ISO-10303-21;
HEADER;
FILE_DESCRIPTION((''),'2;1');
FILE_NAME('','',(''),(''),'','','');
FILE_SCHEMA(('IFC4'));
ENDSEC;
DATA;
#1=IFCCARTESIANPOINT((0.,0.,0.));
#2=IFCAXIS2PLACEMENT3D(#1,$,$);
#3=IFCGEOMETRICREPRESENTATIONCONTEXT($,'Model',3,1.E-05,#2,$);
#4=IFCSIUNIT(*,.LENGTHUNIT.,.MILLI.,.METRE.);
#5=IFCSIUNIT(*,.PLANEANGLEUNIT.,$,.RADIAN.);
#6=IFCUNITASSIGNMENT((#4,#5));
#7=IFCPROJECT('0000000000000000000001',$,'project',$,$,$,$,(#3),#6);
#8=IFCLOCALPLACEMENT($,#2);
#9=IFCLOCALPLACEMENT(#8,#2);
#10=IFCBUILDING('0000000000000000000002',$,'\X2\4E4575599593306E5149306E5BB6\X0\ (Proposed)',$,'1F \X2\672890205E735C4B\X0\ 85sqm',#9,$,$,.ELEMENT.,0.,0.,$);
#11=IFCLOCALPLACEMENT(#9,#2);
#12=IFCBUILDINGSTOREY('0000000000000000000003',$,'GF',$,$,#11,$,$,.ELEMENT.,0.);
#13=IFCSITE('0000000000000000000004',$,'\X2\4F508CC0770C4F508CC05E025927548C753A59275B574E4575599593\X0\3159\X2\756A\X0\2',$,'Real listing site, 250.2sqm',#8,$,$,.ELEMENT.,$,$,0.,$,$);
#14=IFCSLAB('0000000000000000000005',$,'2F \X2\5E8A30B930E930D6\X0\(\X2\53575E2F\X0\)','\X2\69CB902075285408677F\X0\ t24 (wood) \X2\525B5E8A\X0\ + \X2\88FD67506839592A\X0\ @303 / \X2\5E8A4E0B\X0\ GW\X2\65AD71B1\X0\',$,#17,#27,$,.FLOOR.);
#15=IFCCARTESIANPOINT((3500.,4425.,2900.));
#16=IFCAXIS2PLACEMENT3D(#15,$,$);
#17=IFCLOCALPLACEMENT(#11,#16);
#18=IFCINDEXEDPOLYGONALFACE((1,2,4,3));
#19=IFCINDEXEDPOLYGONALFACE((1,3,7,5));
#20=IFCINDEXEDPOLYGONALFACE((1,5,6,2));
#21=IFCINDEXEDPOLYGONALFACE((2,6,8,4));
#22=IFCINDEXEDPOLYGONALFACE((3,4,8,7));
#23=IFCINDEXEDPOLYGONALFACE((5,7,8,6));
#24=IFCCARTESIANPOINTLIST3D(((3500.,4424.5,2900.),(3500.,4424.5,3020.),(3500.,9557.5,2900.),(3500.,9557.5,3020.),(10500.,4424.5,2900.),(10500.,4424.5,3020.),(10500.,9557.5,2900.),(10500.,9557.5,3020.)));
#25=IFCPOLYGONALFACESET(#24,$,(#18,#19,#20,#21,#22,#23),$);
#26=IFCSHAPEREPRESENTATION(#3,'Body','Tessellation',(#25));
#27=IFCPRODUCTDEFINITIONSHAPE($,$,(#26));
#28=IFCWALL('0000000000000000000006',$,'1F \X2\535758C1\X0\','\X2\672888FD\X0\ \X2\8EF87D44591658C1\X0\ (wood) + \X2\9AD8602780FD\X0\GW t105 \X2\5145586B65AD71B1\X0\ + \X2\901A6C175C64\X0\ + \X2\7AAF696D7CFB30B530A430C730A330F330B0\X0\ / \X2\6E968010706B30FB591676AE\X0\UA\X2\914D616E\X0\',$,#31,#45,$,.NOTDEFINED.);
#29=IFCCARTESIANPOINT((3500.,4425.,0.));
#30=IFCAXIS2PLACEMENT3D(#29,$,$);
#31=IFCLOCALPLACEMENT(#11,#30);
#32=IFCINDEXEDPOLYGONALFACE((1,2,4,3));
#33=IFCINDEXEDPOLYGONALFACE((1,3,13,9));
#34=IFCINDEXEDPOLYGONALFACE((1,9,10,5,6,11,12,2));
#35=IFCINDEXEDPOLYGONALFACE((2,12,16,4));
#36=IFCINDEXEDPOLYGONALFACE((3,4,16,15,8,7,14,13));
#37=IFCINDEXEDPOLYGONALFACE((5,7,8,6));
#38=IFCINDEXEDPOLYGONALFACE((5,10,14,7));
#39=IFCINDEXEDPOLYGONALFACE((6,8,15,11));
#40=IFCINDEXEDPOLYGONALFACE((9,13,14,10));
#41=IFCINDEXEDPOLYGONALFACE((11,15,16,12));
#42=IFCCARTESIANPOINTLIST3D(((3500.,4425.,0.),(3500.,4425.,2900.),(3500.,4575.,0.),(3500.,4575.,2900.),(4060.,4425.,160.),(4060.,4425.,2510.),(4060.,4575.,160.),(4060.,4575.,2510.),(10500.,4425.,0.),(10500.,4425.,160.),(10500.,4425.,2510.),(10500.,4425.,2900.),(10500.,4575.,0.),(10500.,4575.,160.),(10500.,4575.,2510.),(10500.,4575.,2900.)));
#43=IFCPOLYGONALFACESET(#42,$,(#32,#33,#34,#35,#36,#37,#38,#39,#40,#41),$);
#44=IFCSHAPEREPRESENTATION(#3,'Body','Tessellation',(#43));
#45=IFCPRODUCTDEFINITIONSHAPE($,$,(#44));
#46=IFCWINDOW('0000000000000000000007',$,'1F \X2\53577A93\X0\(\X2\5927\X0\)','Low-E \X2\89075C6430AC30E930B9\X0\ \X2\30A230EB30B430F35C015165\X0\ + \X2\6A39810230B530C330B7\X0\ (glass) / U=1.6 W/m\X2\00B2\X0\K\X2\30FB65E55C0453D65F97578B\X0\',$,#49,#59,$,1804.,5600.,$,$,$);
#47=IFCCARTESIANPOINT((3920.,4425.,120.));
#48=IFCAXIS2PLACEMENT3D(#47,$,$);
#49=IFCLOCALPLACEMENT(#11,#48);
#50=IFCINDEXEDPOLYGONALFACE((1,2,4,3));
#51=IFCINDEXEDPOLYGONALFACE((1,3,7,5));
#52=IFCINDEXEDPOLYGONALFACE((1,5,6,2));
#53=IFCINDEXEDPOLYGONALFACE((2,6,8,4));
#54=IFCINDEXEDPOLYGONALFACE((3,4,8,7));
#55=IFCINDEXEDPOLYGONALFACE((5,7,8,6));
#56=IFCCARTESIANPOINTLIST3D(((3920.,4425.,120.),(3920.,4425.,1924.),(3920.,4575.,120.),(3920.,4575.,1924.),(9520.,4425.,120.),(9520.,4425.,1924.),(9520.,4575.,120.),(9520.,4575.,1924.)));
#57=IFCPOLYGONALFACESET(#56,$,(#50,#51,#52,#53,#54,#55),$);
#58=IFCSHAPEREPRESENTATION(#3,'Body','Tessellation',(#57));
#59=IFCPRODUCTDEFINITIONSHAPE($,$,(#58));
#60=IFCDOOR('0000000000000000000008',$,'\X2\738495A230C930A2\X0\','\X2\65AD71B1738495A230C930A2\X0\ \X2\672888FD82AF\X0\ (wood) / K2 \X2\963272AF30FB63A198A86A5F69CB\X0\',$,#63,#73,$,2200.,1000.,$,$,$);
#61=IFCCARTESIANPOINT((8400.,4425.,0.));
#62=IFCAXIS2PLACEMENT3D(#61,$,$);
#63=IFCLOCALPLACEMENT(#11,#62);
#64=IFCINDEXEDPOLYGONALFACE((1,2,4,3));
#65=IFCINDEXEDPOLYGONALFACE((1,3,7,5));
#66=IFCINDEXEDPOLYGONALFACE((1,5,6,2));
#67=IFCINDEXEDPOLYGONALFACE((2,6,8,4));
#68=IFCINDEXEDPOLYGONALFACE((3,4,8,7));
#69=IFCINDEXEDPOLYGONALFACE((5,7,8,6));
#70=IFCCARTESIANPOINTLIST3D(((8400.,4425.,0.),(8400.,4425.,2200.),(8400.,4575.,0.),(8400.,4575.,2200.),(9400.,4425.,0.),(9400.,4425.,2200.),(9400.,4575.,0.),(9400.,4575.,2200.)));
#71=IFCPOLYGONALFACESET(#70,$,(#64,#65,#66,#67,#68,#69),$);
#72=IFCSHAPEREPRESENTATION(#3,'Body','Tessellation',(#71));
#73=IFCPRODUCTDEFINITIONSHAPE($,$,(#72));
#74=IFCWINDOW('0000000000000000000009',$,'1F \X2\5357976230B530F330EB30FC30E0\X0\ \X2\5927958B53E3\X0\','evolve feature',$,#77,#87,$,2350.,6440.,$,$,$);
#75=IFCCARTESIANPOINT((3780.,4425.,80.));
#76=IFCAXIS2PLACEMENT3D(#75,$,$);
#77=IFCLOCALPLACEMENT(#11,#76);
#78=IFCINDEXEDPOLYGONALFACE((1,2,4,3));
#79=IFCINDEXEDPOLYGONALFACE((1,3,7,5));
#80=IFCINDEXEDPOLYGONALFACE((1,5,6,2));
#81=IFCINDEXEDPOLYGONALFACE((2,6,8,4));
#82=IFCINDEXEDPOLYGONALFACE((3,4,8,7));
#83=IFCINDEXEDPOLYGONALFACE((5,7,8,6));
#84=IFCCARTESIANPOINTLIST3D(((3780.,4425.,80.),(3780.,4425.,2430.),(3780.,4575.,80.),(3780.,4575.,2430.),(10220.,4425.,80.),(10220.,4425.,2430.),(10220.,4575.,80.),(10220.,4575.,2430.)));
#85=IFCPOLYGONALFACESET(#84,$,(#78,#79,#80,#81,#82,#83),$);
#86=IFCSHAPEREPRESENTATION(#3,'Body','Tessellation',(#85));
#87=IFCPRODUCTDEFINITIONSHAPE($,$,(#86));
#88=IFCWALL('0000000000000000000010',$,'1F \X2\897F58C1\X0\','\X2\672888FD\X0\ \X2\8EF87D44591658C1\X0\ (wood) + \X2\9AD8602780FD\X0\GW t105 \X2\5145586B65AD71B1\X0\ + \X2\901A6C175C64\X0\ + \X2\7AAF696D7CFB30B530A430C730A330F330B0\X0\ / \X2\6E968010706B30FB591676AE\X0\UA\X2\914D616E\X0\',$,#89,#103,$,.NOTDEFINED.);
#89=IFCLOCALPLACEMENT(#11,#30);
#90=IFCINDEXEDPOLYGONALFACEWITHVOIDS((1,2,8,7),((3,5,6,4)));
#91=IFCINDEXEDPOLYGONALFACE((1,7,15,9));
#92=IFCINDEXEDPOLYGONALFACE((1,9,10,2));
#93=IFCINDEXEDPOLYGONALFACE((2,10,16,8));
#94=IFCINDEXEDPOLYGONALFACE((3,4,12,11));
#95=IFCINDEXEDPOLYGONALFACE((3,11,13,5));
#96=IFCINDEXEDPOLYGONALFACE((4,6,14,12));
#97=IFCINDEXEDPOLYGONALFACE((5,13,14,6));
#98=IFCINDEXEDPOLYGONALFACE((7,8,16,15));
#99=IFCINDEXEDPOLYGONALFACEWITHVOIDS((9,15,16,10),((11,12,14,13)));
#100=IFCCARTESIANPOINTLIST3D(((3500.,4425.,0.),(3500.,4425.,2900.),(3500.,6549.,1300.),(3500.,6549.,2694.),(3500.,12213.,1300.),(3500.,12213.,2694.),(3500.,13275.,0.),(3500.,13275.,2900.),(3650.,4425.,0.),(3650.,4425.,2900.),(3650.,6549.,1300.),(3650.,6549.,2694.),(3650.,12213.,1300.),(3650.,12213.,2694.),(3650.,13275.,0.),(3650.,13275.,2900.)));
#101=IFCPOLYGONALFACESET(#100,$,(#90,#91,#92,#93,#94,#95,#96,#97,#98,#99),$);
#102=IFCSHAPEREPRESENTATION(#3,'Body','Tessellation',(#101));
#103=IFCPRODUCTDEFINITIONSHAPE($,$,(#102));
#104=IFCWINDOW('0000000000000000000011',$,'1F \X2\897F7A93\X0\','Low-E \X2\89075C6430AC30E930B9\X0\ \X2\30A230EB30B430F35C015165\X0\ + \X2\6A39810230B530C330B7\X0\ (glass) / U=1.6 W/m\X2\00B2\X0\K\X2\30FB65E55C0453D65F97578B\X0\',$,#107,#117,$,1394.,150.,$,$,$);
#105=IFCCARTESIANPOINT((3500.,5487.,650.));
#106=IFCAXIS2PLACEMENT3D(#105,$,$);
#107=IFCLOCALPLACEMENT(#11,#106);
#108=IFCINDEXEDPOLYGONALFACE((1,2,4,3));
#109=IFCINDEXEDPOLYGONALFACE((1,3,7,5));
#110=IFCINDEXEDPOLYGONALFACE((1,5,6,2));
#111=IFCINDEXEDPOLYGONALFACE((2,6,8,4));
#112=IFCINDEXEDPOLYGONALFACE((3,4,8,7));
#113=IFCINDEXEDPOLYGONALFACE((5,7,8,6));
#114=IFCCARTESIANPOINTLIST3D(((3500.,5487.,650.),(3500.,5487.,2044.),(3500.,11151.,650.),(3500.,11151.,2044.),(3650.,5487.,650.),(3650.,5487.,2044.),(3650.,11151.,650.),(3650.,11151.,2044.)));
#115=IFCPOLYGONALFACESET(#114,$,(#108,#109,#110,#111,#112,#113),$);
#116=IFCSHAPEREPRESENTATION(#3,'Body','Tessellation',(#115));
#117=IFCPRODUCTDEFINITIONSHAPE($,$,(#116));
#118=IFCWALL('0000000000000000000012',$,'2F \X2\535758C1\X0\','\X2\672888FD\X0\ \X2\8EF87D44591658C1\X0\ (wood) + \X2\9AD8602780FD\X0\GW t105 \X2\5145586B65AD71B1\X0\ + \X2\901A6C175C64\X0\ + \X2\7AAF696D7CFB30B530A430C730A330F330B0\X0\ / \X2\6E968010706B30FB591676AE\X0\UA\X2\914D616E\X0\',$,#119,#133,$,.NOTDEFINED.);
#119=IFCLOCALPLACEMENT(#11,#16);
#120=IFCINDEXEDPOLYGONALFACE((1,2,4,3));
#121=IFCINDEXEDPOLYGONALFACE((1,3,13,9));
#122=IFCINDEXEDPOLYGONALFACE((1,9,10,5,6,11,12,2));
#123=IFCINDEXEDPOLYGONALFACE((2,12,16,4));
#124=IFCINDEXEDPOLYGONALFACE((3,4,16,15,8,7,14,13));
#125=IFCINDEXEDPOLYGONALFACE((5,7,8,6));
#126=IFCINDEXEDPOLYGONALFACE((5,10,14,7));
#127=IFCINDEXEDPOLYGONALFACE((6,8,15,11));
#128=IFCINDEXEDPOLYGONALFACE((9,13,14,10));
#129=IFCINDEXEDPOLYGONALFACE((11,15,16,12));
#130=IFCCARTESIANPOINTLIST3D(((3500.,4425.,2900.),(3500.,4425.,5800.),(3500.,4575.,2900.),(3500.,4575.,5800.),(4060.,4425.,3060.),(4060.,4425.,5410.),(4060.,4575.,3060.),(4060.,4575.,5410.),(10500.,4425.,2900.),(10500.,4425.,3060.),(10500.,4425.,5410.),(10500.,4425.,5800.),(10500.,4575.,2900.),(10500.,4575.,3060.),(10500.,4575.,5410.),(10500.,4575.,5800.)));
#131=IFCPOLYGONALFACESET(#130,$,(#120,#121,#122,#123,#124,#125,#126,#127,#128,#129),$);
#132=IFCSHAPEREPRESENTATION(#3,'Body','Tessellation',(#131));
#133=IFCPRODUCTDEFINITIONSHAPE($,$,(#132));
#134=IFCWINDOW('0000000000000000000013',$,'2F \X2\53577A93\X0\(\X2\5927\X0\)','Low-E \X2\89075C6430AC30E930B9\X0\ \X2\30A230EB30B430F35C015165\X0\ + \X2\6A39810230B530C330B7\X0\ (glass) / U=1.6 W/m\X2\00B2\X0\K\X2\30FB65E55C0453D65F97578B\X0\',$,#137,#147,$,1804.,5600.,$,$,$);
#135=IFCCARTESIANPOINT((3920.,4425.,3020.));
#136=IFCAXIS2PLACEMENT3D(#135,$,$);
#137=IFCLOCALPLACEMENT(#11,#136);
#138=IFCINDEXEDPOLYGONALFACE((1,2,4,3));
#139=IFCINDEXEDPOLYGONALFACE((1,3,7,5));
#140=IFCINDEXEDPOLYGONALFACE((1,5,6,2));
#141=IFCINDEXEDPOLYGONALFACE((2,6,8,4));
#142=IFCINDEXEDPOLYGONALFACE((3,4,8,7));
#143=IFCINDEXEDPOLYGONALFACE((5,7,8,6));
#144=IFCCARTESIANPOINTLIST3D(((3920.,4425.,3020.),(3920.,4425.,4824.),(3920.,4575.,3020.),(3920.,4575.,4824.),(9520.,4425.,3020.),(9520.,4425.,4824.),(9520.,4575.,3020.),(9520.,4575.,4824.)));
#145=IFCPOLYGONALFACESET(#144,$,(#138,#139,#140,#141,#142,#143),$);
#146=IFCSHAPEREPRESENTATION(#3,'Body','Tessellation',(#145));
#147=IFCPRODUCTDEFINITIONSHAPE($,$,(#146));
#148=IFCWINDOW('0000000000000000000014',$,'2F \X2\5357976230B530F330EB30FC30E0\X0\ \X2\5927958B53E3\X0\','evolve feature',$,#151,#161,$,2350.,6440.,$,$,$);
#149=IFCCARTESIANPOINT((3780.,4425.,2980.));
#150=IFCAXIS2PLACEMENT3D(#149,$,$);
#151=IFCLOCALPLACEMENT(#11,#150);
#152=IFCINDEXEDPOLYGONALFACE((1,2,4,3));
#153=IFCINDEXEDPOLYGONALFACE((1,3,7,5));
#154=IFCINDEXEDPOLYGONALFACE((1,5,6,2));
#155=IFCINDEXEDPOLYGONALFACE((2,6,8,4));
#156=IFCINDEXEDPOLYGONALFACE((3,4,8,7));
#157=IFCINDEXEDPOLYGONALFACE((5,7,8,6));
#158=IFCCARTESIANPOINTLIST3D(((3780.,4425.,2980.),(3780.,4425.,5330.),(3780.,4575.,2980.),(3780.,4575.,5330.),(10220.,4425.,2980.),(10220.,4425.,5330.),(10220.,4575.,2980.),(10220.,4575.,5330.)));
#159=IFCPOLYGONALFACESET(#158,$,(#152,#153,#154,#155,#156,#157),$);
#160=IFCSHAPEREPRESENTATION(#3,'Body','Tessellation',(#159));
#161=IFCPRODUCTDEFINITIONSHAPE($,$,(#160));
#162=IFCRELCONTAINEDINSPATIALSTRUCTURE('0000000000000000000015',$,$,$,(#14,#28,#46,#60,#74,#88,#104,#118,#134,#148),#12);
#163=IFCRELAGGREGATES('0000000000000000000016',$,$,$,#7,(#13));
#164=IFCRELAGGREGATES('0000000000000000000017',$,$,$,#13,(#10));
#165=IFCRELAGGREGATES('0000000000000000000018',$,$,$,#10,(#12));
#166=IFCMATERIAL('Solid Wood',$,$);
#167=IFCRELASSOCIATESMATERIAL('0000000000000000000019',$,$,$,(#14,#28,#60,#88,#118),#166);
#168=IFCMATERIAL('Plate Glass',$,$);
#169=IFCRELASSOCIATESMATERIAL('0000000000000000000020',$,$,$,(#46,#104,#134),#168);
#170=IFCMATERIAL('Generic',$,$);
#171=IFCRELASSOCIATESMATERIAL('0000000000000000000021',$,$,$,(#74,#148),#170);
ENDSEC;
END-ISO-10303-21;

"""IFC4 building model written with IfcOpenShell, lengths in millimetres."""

from ifc_helpers import new_model, si_unit, frame, frame_2d, origin, place, context, project, spatial, rectangle, extrude, material, element, fill, save


model = new_model("IFC4")

# Units and contexts
model_context = context("Model", 3, precision=1e-05, world=origin())
ifc_project = project(units=[si_unit("LENGTHUNIT", "METRE", prefix="MILLI"), si_unit("PLANEANGLEUNIT", "RADIAN")], contexts=[model_context])

# Site, building, storey
site_placement = place(None, origin())
site = spatial("IfcSite", under=ifc_project, at=site_placement, Name="佐賀県佐賀市大和町大字久留間3159番2", ObjectType="Real listing site, 250.2sqm", CompositionType="ELEMENT", RefElevation=0.0)
building_placement = place(site_placement, origin())
building = spatial("IfcBuilding", under=site, at=building_placement, Name="久留間の光の家 (Proposed)", ObjectType="1F 木造平屋 85sqm", CompositionType="ELEMENT", ElevationOfRefHeight=0.0, ElevationOfTerrain=0.0)
storey_placement = place(building_placement, origin())
storey = spatial("IfcBuildingStorey", under=building, at=storey_placement, Name="GF", CompositionType="ELEMENT", Elevation=0.0)

# Slab
ifc_material_1 = material(Name="Solid Wood")
slab_1_placement = place(storey_placement, frame((3500.0, 4425.0, 2900.0)))
element("IfcSlab", 1, at=slab_1_placement, inside=storey, material=ifc_material_1, Name="2F 床スラブ(南帯)", Description="構造用合板 t24 (wood) 剛床 + 製材根太 @303 / 床下 GW断熱", PredefinedType="FLOOR", context=model_context, shape_type="SweptSolid", body=[
    extrude(rectangle(XDim=7000.0, YDim=5133.0, at=frame_2d((3500.0, 2566.0))), frame((3500.0, 4425.0, 2900.0)), (0.0, 0.0, 1.0), 120.0),
])
ifc_material_2 = material(Name="Generic")

# Wall, openings, windows, door
wall_1_placement = place(storey_placement, frame((3500.0, 4425.0, 0.0)))
wall_1 = element("IfcWall", 2, at=wall_1_placement, inside=storey, material=ifc_material_1, Name="1F 南壁", Description="木製 軸組外壁 (wood) + 高性能GW t105 充填断熱 + 通気層 + 窯業系サイディング / 準耐火・外皮UA配慮", PredefinedType="NOTDEFINED", context=model_context, shape_type="SweptSolid", body=[
    extrude(rectangle(XDim=7000.0, YDim=150.0, at=frame_2d((3500.0, 75.0))), frame((3500.0, 4425.0, 0.0)), (0.0, 0.0, 1.0), 2900.0),
])
opening_1_placement = place(storey_placement, frame((3920.0, 4425.0, 120.0)))
opening_1 = element("IfcOpeningElement", 3, at=opening_1_placement, cuts=wall_1, PredefinedType="NOTDEFINED", context=model_context, shape_type="SweptSolid", body=[
    extrude(rectangle(XDim=5600.0, YDim=150.0, at=frame_2d((2800.0, 75.0))), frame((3920.0, 4425.0, 120.0)), (0.0, 0.0, 1.0), 1804.0),
])
opening_2_placement = place(storey_placement, frame((8400.0, 4425.0, 0.0)))
opening_2 = element("IfcOpeningElement", 4, at=opening_2_placement, cuts=wall_1, PredefinedType="NOTDEFINED", context=model_context, shape_type="SweptSolid", body=[
    extrude(rectangle(XDim=1000.0, YDim=150.0, at=frame_2d((500.0, 75.0))), frame((8400.0, 4425.0, 0.0)), (0.0, 0.0, 1.0), 2200.0),
])
opening_3_placement = place(storey_placement, frame((3780.0, 4425.0, 80.0)))
opening_3 = element("IfcOpeningElement", 5, at=opening_3_placement, cuts=wall_1, PredefinedType="NOTDEFINED", context=model_context, shape_type="SweptSolid", body=[
    extrude(rectangle(XDim=6440.0, YDim=150.0, at=frame_2d((3220.0, 75.0))), frame((3780.0, 4425.0, 80.0)), (0.0, 0.0, 1.0), 2350.0),
])
ifc_material_3 = material(Name="Plate Glass")
window_1_placement = place(storey_placement, frame((3920.0, 4425.0, 120.0)))
window_1 = element("IfcWindow", 6, at=window_1_placement, inside=storey, material=ifc_material_3, Name="1F 南窓(大)", Description="Low-E 複層ガラス アルゴン封入 + 樹脂サッシ (glass) / U=1.6 W/m²K・日射取得型", OverallHeight=1804.0, OverallWidth=5600.0, context=model_context, shape_type="SweptSolid", body=[
    extrude(rectangle(XDim=5600.0, YDim=150.0, at=frame_2d((2800.0, 75.0))), frame((3920.0, 4425.0, 120.0)), (0.0, 0.0, 1.0), 1804.0),
])
fill(opening_1, window_1)
door_placement = place(storey_placement, frame((8400.0, 4425.0, 0.0)))
door = element("IfcDoor", 7, at=door_placement, inside=storey, material=ifc_material_1, Name="玄関ドア", Description="断熱玄関ドア 木製芯 (wood) / K2 防犯・採風機構", OverallHeight=2200.0, OverallWidth=1000.0, context=model_context, shape_type="SweptSolid", body=[
    extrude(rectangle(XDim=1000.0, YDim=150.0, at=frame_2d((500.0, 75.0))), frame((8400.0, 4425.0, 0.0)), (0.0, 0.0, 1.0), 2200.0),
])
fill(opening_2, door)
window_2_placement = place(storey_placement, frame((3780.0, 4425.0, 80.0)))
window_2 = element("IfcWindow", 8, at=window_2_placement, inside=storey, material=ifc_material_2, Name="1F 南面サンルーム 大開口", Description="evolve feature", OverallHeight=2350.0, OverallWidth=6440.0, context=model_context, shape_type="SweptSolid", body=[
    extrude(rectangle(XDim=6440.0, YDim=150.0, at=frame_2d((3220.0, 75.0))), frame((3780.0, 4425.0, 80.0)), (0.0, 0.0, 1.0), 2350.0),
])
fill(opening_3, window_2)

# Wall, opening, window
wall_2_placement = place(storey_placement, frame((3500.0, 4425.0, 0.0)))
wall_2 = element("IfcWall", 9, at=wall_2_placement, inside=storey, material=ifc_material_1, Name="1F 西壁", Description="木製 軸組外壁 (wood) + 高性能GW t105 充填断熱 + 通気層 + 窯業系サイディング / 準耐火・外皮UA配慮", PredefinedType="NOTDEFINED", context=model_context, shape_type="SweptSolid", body=[
    extrude(rectangle(XDim=150.0, YDim=8850.0, at=frame_2d((75.0, 4425.0))), frame((3500.0, 4425.0, 0.0)), (0.0, 0.0, 1.0), 2900.0),
])
opening_4_placement = place(storey_placement, frame((3500.0, 5487.0, 650.0)))
opening_4 = element("IfcOpeningElement", 10, at=opening_4_placement, cuts=wall_2, PredefinedType="NOTDEFINED", context=model_context, shape_type="SweptSolid", body=[
    extrude(rectangle(XDim=150.0, YDim=5664.0, at=frame_2d((75.0, 2832.0))), frame((3500.0, 5487.0, 650.0)), (0.0, 0.0, 1.0), 1394.0),
])
window_3_placement = place(storey_placement, frame((3500.0, 5487.0, 650.0)))
window_3 = element("IfcWindow", 11, at=window_3_placement, inside=storey, material=ifc_material_3, Name="1F 西窓", Description="Low-E 複層ガラス アルゴン封入 + 樹脂サッシ (glass) / U=1.6 W/m²K・日射取得型", OverallHeight=1394.0, OverallWidth=150.0, context=model_context, shape_type="SweptSolid", body=[
    extrude(rectangle(XDim=150.0, YDim=5664.0, at=frame_2d((75.0, 2832.0))), frame((3500.0, 5487.0, 650.0)), (0.0, 0.0, 1.0), 1394.0),
])
fill(opening_4, window_3)

# Wall, openings, windows
wall_3_placement = place(storey_placement, frame((3500.0, 4425.0, 2900.0)))
wall_3 = element("IfcWall", 12, at=wall_3_placement, inside=storey, material=ifc_material_1, Name="2F 南壁", Description="木製 軸組外壁 (wood) + 高性能GW t105 充填断熱 + 通気層 + 窯業系サイディング / 準耐火・外皮UA配慮", PredefinedType="NOTDEFINED", context=model_context, shape_type="SweptSolid", body=[
    extrude(rectangle(XDim=7000.0, YDim=150.0, at=frame_2d((3500.0, 75.0))), frame((3500.0, 4425.0, 2900.0)), (0.0, 0.0, 1.0), 2900.0),
])
opening_5_placement = place(storey_placement, frame((3920.0, 4425.0, 3020.0)))
opening_5 = element("IfcOpeningElement", 13, at=opening_5_placement, cuts=wall_3, PredefinedType="NOTDEFINED", context=model_context, shape_type="SweptSolid", body=[
    extrude(rectangle(XDim=5600.0, YDim=150.0, at=frame_2d((2800.0, 75.0))), frame((3920.0, 4425.0, 3020.0)), (0.0, 0.0, 1.0), 1804.0),
])
opening_6_placement = place(storey_placement, frame((3780.0, 4425.0, 2980.0)))
opening_6 = element("IfcOpeningElement", 14, at=opening_6_placement, cuts=wall_3, PredefinedType="NOTDEFINED", context=model_context, shape_type="SweptSolid", body=[
    extrude(rectangle(XDim=6440.0, YDim=150.0, at=frame_2d((3220.0, 75.0))), frame((3780.0, 4425.0, 2980.0)), (0.0, 0.0, 1.0), 2350.0),
])
window_4_placement = place(storey_placement, frame((3920.0, 4425.0, 3020.0)))
window_4 = element("IfcWindow", 15, at=window_4_placement, inside=storey, material=ifc_material_3, Name="2F 南窓(大)", Description="Low-E 複層ガラス アルゴン封入 + 樹脂サッシ (glass) / U=1.6 W/m²K・日射取得型", OverallHeight=1804.0, OverallWidth=5600.0, context=model_context, shape_type="SweptSolid", body=[
    extrude(rectangle(XDim=5600.0, YDim=150.0, at=frame_2d((2800.0, 75.0))), frame((3920.0, 4425.0, 3020.0)), (0.0, 0.0, 1.0), 1804.0),
])
fill(opening_5, window_4)
window_5_placement = place(storey_placement, frame((3780.0, 4425.0, 2980.0)))
window_5 = element("IfcWindow", 16, at=window_5_placement, inside=storey, material=ifc_material_2, Name="2F 南面サンルーム 大開口", Description="evolve feature", OverallHeight=2350.0, OverallWidth=6440.0, context=model_context, shape_type="SweptSolid", body=[
    extrude(rectangle(XDim=6440.0, YDim=150.0, at=frame_2d((3220.0, 75.0))), frame((3780.0, 4425.0, 2980.0)), (0.0, 0.0, 1.0), 2350.0),
])
fill(opening_6, window_5)

save(model, "model.ifc")
